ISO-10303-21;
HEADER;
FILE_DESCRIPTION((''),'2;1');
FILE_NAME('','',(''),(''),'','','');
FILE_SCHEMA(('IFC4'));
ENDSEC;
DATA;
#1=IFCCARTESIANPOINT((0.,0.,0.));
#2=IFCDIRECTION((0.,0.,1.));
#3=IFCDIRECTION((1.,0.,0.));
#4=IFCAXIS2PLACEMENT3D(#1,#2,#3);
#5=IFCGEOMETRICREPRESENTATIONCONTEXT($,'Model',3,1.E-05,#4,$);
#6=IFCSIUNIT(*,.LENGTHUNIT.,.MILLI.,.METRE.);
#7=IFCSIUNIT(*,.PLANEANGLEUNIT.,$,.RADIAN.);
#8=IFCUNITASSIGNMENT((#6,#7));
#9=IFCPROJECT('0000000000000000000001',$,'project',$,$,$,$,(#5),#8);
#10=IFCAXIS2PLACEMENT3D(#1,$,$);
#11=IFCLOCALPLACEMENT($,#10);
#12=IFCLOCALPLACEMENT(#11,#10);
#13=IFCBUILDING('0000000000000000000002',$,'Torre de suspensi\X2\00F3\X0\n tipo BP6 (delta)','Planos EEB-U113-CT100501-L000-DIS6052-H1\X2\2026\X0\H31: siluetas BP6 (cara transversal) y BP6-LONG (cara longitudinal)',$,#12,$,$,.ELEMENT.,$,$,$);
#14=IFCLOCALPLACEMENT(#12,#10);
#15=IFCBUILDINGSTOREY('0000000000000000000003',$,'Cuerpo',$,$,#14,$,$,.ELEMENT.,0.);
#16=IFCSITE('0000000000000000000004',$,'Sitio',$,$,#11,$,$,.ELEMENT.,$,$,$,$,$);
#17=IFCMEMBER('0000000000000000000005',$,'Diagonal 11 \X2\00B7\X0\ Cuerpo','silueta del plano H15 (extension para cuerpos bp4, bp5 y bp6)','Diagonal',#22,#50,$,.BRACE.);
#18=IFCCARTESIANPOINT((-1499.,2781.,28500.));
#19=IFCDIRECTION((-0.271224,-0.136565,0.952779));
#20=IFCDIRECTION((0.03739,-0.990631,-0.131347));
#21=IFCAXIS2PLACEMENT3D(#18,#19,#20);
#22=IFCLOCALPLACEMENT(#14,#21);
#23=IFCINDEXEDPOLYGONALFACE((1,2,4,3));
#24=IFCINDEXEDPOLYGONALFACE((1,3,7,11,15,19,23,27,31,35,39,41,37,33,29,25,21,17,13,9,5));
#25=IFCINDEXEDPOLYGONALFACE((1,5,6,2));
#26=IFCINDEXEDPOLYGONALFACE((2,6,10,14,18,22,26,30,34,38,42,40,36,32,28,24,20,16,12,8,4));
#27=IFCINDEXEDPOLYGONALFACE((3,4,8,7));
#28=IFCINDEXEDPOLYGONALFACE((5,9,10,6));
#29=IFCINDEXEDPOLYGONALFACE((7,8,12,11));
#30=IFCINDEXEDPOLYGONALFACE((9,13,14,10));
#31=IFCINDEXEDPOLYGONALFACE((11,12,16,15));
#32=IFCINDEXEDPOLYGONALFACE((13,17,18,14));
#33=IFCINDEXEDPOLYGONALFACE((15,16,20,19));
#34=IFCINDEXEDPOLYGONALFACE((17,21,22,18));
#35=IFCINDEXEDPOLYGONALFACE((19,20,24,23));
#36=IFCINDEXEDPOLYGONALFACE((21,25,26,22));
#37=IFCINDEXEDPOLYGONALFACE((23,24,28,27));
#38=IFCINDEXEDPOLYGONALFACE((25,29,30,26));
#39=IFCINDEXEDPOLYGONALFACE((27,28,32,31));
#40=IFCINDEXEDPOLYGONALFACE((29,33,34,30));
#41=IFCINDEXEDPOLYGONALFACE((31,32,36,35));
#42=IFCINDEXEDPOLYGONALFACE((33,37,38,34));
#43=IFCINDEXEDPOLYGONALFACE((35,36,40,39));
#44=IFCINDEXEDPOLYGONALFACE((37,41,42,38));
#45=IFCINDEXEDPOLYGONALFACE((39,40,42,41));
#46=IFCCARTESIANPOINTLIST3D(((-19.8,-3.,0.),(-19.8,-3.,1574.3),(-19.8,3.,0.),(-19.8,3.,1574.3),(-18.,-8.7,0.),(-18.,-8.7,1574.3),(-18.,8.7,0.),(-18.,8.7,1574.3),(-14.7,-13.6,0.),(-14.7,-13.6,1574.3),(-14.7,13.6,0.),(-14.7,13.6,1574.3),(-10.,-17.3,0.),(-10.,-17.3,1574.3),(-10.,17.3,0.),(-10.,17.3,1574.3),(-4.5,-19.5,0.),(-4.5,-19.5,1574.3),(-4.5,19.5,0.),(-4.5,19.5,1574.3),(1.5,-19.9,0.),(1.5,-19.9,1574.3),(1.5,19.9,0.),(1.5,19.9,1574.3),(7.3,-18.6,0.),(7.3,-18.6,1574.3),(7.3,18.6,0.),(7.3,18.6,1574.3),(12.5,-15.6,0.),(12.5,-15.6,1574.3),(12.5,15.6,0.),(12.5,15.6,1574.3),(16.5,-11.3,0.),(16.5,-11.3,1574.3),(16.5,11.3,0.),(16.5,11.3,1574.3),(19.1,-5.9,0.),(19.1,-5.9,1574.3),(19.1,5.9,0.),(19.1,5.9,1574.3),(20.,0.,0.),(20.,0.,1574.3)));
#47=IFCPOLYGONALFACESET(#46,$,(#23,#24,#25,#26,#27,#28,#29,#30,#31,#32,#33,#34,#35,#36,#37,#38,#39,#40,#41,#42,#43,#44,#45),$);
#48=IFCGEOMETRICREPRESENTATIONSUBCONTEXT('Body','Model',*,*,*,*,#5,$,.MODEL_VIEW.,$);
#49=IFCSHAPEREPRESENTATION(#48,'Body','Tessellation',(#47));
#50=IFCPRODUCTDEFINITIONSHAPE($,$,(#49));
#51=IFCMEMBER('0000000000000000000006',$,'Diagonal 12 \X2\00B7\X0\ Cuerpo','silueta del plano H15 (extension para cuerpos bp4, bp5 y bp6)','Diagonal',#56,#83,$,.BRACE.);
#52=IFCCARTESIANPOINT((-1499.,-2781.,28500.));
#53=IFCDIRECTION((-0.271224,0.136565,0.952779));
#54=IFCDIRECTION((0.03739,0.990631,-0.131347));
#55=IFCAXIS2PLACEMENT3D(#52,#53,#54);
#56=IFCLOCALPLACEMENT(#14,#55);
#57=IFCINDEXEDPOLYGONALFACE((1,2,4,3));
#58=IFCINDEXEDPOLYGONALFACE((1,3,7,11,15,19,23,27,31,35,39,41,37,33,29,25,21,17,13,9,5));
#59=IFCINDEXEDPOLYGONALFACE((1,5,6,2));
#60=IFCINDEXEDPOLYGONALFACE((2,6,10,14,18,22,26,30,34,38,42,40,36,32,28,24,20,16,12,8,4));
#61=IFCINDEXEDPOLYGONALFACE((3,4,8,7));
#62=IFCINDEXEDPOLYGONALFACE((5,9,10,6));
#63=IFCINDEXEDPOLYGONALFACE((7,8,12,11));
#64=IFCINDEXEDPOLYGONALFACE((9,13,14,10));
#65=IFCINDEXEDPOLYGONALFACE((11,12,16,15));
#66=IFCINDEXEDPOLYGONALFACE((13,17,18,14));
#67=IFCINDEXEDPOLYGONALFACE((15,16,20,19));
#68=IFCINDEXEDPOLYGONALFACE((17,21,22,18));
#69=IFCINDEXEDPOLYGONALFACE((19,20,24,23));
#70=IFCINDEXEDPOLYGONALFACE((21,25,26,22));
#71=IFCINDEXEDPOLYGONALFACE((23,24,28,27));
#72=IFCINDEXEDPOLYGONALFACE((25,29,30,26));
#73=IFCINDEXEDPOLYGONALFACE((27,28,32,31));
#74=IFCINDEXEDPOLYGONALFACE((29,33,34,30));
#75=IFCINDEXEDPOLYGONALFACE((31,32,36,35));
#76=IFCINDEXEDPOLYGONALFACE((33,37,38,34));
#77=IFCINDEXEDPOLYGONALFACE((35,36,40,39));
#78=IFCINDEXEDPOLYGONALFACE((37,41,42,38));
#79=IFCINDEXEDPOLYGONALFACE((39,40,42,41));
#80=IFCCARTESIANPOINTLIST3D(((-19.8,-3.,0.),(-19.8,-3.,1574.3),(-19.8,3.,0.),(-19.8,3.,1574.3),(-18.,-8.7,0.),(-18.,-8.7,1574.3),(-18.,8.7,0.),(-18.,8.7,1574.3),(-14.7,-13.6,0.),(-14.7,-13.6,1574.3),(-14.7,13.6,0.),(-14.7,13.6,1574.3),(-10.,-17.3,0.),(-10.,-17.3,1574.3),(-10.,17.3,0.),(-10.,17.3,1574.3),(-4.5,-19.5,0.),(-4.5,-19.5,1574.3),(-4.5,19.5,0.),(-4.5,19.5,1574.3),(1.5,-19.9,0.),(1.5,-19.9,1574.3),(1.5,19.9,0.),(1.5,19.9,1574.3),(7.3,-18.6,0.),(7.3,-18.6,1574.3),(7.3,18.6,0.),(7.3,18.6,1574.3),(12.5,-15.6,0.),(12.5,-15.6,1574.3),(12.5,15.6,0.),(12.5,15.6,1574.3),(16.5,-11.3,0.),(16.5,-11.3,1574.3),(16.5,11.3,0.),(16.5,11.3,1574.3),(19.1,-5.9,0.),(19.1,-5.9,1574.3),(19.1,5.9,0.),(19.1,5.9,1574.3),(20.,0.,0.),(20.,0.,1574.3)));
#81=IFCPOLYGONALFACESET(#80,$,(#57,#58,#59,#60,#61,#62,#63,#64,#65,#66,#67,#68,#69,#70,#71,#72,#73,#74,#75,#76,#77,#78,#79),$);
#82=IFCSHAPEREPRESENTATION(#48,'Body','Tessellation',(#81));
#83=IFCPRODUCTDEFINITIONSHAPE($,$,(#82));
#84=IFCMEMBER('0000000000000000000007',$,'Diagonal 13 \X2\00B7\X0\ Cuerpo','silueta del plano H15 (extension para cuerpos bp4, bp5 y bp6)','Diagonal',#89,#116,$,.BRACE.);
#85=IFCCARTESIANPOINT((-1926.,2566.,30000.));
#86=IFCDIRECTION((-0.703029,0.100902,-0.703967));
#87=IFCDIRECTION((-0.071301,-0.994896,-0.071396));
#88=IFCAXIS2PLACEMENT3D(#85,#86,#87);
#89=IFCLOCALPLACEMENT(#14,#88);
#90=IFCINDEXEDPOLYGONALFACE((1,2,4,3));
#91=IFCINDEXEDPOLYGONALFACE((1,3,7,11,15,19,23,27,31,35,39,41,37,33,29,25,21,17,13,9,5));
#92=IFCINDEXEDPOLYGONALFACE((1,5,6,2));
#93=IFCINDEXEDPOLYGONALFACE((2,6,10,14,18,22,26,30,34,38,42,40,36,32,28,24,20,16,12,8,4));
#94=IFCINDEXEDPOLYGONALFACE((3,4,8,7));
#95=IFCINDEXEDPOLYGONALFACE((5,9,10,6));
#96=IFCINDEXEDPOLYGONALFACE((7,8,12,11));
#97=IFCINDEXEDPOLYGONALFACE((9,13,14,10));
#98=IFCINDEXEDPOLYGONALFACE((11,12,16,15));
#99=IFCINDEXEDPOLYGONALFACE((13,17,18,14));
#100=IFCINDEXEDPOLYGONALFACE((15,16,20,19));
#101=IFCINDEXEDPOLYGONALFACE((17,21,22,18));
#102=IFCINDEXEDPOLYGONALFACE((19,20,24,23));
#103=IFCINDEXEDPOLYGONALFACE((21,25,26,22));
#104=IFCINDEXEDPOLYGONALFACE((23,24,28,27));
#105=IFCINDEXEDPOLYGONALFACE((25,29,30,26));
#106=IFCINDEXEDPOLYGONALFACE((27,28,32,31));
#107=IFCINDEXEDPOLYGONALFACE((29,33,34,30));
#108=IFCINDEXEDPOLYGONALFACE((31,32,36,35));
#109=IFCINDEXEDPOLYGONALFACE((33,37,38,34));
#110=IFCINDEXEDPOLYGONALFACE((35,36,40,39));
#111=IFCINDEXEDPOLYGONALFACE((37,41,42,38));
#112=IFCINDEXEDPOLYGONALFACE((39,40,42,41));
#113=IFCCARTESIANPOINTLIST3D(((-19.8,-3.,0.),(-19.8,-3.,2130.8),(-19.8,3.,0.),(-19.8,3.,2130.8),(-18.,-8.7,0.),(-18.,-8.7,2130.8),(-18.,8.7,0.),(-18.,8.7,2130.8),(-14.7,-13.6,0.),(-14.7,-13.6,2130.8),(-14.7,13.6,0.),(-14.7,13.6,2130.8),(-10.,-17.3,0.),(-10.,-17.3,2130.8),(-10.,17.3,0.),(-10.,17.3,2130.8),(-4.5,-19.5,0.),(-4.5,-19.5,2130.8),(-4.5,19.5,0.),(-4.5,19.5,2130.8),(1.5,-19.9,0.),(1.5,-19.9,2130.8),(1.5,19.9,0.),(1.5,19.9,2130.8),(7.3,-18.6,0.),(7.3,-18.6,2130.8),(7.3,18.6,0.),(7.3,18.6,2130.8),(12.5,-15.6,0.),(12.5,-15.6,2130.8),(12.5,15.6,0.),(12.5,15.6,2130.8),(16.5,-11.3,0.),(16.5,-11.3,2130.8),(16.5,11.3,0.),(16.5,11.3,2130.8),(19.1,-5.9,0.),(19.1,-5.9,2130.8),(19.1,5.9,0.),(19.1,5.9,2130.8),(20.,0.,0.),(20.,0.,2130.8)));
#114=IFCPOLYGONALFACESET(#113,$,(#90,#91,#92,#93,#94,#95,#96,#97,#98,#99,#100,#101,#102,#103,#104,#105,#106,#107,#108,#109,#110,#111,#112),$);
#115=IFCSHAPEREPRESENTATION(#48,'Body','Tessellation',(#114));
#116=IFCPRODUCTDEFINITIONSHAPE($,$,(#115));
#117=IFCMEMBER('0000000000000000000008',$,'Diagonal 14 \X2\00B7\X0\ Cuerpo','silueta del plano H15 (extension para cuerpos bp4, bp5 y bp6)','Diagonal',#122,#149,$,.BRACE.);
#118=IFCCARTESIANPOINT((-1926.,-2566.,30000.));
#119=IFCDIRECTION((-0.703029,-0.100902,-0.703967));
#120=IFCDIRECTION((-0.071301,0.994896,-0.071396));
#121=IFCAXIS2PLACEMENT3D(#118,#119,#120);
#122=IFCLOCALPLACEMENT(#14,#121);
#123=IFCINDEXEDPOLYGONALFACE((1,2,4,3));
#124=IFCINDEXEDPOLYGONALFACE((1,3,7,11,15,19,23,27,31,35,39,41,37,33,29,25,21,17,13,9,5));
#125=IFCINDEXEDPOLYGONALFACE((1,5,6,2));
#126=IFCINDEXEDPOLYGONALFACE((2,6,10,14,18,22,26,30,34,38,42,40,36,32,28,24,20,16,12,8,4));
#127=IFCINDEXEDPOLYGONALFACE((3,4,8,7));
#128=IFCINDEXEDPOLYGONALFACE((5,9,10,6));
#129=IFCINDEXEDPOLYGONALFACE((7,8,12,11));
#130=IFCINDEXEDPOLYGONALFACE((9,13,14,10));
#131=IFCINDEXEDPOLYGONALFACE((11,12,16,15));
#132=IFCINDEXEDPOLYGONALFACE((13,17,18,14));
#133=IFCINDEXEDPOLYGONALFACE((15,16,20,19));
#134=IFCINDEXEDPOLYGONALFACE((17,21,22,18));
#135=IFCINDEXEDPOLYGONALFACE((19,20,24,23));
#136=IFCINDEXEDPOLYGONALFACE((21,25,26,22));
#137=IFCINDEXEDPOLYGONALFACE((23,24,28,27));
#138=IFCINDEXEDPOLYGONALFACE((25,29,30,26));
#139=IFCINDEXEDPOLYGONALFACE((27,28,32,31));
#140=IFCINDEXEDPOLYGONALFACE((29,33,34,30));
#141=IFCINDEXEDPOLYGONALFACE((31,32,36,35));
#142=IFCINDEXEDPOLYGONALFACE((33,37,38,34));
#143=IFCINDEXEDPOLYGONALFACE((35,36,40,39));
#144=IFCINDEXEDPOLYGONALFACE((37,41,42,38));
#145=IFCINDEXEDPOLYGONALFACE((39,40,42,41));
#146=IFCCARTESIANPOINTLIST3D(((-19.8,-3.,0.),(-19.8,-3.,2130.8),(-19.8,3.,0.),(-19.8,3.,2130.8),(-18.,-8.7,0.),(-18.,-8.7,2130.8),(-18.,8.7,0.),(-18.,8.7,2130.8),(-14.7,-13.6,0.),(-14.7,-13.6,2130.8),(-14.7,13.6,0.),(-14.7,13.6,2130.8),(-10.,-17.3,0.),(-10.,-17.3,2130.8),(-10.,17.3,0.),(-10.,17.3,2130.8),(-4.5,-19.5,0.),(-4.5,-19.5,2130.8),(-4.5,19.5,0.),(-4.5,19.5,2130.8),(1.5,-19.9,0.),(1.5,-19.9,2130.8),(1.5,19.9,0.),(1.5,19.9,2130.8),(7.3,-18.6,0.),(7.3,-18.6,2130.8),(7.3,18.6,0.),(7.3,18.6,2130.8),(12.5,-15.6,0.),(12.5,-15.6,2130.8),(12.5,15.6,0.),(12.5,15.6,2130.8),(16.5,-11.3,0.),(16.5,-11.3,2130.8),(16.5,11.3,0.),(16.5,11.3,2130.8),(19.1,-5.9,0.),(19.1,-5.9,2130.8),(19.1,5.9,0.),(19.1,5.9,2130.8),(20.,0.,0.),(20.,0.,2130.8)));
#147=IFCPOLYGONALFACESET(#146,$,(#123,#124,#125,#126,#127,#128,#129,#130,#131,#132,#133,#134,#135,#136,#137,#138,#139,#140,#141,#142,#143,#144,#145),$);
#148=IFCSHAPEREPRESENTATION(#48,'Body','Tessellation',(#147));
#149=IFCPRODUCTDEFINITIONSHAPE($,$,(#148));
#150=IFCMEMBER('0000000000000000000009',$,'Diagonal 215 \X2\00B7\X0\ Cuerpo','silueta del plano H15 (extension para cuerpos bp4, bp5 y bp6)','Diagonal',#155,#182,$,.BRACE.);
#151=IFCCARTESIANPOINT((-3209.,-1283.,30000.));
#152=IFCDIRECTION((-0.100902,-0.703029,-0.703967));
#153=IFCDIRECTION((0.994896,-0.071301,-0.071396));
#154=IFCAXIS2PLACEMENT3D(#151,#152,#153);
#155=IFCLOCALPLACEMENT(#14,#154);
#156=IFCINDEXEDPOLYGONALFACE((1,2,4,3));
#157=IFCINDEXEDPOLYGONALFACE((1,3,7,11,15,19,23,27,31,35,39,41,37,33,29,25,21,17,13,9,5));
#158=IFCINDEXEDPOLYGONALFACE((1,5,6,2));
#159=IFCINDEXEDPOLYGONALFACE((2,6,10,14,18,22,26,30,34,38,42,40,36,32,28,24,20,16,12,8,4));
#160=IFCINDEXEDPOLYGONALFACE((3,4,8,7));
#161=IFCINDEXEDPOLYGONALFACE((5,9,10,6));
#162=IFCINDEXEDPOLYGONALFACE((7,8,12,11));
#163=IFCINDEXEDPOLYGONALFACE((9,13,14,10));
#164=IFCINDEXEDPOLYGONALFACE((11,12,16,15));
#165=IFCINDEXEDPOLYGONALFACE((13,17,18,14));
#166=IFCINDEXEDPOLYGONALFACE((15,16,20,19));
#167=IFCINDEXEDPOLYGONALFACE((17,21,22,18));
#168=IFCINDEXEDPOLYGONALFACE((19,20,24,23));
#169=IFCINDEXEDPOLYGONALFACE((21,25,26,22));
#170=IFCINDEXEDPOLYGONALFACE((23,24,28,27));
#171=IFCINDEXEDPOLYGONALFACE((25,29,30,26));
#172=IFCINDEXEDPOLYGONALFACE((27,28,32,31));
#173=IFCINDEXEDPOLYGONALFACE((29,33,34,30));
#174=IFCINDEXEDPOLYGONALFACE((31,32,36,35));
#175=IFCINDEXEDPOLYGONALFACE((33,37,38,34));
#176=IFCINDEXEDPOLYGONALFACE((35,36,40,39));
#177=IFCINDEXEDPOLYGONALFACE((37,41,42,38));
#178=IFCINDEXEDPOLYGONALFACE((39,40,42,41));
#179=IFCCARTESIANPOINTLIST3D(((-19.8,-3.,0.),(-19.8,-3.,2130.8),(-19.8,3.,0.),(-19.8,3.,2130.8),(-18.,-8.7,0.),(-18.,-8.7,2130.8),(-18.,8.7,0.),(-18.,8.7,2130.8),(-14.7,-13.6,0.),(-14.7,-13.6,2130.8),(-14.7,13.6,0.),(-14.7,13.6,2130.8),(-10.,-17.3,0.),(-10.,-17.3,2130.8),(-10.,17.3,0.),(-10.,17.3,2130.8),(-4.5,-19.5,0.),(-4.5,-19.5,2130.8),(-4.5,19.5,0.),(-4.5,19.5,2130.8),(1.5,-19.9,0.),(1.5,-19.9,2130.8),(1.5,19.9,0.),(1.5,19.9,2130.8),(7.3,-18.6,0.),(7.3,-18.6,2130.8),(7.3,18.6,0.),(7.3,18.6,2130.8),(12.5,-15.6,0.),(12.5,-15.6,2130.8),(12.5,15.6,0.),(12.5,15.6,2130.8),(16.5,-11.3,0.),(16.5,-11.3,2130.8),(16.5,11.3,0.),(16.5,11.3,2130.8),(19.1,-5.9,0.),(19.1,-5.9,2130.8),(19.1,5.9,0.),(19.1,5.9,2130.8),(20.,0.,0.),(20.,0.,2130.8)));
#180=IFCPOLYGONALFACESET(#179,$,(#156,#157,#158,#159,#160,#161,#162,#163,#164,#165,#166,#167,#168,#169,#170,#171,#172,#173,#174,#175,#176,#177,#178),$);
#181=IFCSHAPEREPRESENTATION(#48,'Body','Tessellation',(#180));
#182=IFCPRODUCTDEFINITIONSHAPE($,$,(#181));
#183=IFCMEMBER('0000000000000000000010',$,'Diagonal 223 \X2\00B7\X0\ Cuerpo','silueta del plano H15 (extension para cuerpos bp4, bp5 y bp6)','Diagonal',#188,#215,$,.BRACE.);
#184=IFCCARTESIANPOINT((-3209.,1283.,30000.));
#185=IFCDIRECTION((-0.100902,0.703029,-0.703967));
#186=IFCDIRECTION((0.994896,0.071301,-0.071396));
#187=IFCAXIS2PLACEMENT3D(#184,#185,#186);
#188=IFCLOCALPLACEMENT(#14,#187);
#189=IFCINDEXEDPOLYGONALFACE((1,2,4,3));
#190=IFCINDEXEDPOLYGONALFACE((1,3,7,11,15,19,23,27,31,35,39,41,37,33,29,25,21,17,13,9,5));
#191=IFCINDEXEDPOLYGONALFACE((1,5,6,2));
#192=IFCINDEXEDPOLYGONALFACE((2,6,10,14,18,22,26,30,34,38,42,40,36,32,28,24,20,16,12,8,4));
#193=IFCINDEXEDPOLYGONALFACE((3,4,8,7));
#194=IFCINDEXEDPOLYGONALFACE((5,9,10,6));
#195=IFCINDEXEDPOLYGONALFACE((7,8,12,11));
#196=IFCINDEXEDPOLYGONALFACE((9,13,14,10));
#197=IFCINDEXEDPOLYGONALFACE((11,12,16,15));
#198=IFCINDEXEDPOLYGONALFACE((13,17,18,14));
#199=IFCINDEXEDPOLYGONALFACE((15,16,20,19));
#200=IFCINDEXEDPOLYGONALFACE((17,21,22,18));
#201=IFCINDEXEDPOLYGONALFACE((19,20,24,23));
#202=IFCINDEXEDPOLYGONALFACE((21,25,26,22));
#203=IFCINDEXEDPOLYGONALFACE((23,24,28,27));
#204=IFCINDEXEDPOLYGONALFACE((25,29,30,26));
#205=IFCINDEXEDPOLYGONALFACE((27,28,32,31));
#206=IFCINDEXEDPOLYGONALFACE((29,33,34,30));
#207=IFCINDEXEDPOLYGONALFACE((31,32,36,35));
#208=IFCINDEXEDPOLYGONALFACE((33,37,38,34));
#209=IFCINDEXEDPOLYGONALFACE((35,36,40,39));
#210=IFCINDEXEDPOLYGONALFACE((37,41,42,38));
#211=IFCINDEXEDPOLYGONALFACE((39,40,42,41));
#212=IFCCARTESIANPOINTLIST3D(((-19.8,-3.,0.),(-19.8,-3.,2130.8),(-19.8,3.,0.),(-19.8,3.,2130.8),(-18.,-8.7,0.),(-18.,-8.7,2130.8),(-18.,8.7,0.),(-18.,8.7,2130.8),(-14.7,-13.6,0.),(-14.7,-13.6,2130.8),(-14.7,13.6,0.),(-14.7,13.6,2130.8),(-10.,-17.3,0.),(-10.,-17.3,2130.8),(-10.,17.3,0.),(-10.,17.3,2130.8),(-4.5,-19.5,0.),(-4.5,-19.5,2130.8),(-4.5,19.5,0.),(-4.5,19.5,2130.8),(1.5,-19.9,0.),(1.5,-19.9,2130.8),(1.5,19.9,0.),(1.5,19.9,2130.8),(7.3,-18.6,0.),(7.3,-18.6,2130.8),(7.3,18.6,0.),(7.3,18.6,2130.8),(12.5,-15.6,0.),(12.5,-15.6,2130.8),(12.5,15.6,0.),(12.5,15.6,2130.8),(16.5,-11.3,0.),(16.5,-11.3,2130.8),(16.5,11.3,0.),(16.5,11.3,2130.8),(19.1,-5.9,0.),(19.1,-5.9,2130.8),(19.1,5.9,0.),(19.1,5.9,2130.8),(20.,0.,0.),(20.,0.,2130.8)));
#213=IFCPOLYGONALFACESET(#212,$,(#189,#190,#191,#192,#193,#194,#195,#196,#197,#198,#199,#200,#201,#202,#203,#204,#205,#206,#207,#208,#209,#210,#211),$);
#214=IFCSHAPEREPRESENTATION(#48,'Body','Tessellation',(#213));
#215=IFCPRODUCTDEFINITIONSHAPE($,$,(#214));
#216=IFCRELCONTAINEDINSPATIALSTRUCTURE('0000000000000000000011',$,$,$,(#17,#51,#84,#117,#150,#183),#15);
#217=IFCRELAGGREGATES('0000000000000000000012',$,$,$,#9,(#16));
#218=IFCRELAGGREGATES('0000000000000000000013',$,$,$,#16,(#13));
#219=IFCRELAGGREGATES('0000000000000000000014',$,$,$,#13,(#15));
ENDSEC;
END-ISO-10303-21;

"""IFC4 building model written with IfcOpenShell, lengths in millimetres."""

from ifc_helpers import new_model, si_unit, frame, origin, origin_with_axes, place, context, subcontext, project, spatial, circle, extrude, element, save


model = new_model("IFC4")

# Units and contexts
model_context = context("Model", 3, precision=1e-05, world=origin_with_axes())
body_context = subcontext(model_context, "Body", "Model", "MODEL_VIEW")
ifc_project = project(units=[si_unit("LENGTHUNIT", "METRE", prefix="MILLI"), si_unit("PLANEANGLEUNIT", "RADIAN")], contexts=[model_context])

# Site, building, storey
site_placement = place(None, origin())
site = spatial("IfcSite", under=ifc_project, at=site_placement, Name="Sitio", CompositionType="ELEMENT")
building_placement = place(site_placement, origin())
building = spatial("IfcBuilding", under=site, at=building_placement, Name="Torre de suspensión tipo BP6 (delta)", Description="Planos EEB-U113-CT100501-L000-DIS6052-H1…H31: siluetas BP6 (cara transversal) y BP6-LONG (cara longitudinal)", CompositionType="ELEMENT")
storey_placement = place(building_placement, origin())
storey = spatial("IfcBuildingStorey", under=building, at=storey_placement, Name="Cuerpo", CompositionType="ELEMENT", Elevation=0.0)

# Members
for number, where, z_axis, x_axis, name in (
    (1, (-1499.0, 2781.0, 28500.0), (-0.271224, -0.136565, 0.952779), (0.03739, -0.990631, -0.131347), "Diagonal 11 · Cuerpo"),
    (2, (-1499.0, -2781.0, 28500.0), (-0.271224, 0.136565, 0.952779), (0.03739, 0.990631, -0.131347), "Diagonal 12 · Cuerpo"),
):
    element("IfcMember", number, at=place(storey_placement, frame(where, z_axis=z_axis, x_axis=x_axis)), inside=storey, Name=name, Description="silueta del plano H15 (extension para cuerpos bp4, bp5 y bp6)", ObjectType="Diagonal", PredefinedType="BRACE", context=body_context, shape_type="SweptSolid", body=[
        extrude(circle(Radius=20.0), None, (0.0, 0.0, 1.0), 1574.3),
    ])
for number, where, z_axis, x_axis, name in (
    (3, (-1926.0, 2566.0, 30000.0), (-0.703029, 0.100902, -0.703967), (-0.071301, -0.994896, -0.071396), "Diagonal 13 · Cuerpo"),
    (4, (-1926.0, -2566.0, 30000.0), (-0.703029, -0.100902, -0.703967), (-0.071301, 0.994896, -0.071396), "Diagonal 14 · Cuerpo"),
):
    element("IfcMember", number, at=place(storey_placement, frame(where, z_axis=z_axis, x_axis=x_axis)), inside=storey, Name=name, Description="silueta del plano H15 (extension para cuerpos bp4, bp5 y bp6)", ObjectType="Diagonal", PredefinedType="BRACE", context=body_context, shape_type="SweptSolid", body=[
        extrude(circle(Radius=20.0), None, (0.0, 0.0, 1.0), 2130.8),
    ])
for number, where, z_axis, x_axis, name in (
    (5, (-3209.0, -1283.0, 30000.0), (-0.100902, -0.703029, -0.703967), (0.994896, -0.071301, -0.071396), "Diagonal 215 · Cuerpo"),
    (6, (-3209.0, 1283.0, 30000.0), (-0.100902, 0.703029, -0.703967), (0.994896, 0.071301, -0.071396), "Diagonal 223 · Cuerpo"),
):
    element("IfcMember", number, at=place(storey_placement, frame(where, z_axis=z_axis, x_axis=x_axis)), inside=storey, Name=name, Description="silueta del plano H15 (extension para cuerpos bp4, bp5 y bp6)", ObjectType="Diagonal", PredefinedType="BRACE", context=body_context, shape_type="SweptSolid", body=[
        extrude(circle(Radius=20.0), None, (0.0, 0.0, 1.0), 2130.8),
    ])

save(model, "model.ifc")
